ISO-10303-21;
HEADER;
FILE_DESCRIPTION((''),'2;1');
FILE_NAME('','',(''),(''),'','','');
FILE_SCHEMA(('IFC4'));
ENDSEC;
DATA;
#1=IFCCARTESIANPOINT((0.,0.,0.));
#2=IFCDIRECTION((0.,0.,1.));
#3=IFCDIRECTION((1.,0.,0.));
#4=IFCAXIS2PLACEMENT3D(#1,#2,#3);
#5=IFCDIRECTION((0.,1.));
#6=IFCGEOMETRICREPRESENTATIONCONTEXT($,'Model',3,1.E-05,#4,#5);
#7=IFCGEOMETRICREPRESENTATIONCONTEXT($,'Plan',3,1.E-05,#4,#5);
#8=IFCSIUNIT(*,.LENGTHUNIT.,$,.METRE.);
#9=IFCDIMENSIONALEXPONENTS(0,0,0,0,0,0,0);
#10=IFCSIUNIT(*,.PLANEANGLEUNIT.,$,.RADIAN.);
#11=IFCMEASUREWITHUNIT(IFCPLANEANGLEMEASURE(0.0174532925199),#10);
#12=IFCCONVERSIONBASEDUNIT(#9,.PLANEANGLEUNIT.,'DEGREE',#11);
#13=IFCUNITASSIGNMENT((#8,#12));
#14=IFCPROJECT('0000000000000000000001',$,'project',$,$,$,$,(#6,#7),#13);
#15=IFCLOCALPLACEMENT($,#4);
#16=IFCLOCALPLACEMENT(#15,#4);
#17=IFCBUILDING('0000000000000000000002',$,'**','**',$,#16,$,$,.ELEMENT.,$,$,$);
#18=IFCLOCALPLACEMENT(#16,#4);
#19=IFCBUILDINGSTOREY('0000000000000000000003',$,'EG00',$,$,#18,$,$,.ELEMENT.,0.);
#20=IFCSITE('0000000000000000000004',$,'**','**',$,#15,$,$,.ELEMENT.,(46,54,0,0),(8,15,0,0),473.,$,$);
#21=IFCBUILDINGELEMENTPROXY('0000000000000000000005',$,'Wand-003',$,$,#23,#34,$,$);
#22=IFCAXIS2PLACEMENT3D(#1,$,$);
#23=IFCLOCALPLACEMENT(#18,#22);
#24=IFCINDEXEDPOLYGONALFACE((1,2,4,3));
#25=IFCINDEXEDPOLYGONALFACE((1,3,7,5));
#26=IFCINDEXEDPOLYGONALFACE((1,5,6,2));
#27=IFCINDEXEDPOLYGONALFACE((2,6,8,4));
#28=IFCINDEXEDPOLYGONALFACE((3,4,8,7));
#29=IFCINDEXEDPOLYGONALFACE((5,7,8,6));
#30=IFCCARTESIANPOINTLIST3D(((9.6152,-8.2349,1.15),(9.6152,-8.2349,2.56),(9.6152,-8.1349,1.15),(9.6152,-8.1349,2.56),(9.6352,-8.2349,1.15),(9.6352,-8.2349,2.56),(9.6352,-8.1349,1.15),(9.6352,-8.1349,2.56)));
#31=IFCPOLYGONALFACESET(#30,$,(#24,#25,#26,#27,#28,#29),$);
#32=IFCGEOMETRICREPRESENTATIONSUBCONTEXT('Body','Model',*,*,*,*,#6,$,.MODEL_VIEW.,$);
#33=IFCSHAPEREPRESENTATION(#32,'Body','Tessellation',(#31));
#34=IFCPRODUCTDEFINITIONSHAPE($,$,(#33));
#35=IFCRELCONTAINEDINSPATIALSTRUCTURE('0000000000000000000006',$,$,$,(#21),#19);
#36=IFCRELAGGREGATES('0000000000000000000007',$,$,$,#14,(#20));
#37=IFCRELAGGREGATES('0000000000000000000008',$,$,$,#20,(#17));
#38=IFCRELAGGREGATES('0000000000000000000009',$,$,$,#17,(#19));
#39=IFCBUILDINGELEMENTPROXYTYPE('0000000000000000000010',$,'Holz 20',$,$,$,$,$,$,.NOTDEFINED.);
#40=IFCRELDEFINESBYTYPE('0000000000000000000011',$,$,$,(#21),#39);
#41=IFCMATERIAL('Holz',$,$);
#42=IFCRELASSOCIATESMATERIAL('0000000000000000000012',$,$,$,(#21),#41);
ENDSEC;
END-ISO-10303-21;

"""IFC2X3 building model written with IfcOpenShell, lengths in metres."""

from ifc_helpers import new_model, entity, si_unit, converted_unit, direction, frame, origin_with_axes, place, context, subcontext, project, spatial, polyline, outline, extrude, material, type_object, element, save


model = new_model("IFC2X3")

# Units and contexts
model_context = context("Model", 3, precision=1e-05, world=origin_with_axes(), true_north=direction((0.0, 1.0)))
plan_context = context("Plan", 3, precision=1e-05, world=origin_with_axes(), true_north=direction((0.0, 1.0)))
body_context = subcontext(model_context, "Body", "Model", "MODEL_VIEW")
ifc_project = project(units=[si_unit("LENGTHUNIT", "METRE"), converted_unit("PLANEANGLEUNIT", "DEGREE", entity("IfcPlaneAngleMeasure", 0.0174532925199), si_unit("PLANEANGLEUNIT", "RADIAN"), dimensions=[0, 0, 0, 0, 0, 0, 0])], contexts=[model_context, plan_context])

# Site, building, storey
site_placement = place(None, origin_with_axes())
site = spatial("IfcSite", under=ifc_project, at=site_placement, Name="**", Description="**", CompositionType="ELEMENT", RefLatitude=(46, 54, 0, 0), RefLongitude=(8, 15, 0, 0), RefElevation=473.0)
building_placement = place(site_placement, origin_with_axes())
building = spatial("IfcBuilding", under=site, at=building_placement, Name="**", Description="**", CompositionType="ELEMENT")
storey_placement = place(building_placement, origin_with_axes())
storey = spatial("IfcBuildingStorey", under=building, at=storey_placement, Name="EG00", CompositionType="ELEMENT", Elevation=0.0)

# Shared definitions
ifc_material_1 = material(Name="Holz")

# Building element proxy
building_element_proxy_type_1 = type_object("IfcBuildingElementProxyType", Name="Holz 20", PredefinedType="NOTDEFINED")
proxy_1_placement = place(storey_placement, frame((9.6352, -8.1349, 1.15), z_axis=(0.0, 0.0, 1.0), x_axis=(0.0, -1.0, 0.0)))
element("IfcBuildingElementProxy", 1, at=proxy_1_placement, inside=storey, type_object=building_element_proxy_type_1, material=ifc_material_1, Name="Wand-003", context=body_context, shape_type="SweptSolid", body=[
    extrude(outline(polyline([(0.0, -0.02), (0.1, -0.02), (0.1, 0.0), (0.0, 0.0), (0.0, -0.02)])), origin_with_axes(), (0.0, 0.0, 1.0), 1.41),
])

save(model, "model.ifc")
